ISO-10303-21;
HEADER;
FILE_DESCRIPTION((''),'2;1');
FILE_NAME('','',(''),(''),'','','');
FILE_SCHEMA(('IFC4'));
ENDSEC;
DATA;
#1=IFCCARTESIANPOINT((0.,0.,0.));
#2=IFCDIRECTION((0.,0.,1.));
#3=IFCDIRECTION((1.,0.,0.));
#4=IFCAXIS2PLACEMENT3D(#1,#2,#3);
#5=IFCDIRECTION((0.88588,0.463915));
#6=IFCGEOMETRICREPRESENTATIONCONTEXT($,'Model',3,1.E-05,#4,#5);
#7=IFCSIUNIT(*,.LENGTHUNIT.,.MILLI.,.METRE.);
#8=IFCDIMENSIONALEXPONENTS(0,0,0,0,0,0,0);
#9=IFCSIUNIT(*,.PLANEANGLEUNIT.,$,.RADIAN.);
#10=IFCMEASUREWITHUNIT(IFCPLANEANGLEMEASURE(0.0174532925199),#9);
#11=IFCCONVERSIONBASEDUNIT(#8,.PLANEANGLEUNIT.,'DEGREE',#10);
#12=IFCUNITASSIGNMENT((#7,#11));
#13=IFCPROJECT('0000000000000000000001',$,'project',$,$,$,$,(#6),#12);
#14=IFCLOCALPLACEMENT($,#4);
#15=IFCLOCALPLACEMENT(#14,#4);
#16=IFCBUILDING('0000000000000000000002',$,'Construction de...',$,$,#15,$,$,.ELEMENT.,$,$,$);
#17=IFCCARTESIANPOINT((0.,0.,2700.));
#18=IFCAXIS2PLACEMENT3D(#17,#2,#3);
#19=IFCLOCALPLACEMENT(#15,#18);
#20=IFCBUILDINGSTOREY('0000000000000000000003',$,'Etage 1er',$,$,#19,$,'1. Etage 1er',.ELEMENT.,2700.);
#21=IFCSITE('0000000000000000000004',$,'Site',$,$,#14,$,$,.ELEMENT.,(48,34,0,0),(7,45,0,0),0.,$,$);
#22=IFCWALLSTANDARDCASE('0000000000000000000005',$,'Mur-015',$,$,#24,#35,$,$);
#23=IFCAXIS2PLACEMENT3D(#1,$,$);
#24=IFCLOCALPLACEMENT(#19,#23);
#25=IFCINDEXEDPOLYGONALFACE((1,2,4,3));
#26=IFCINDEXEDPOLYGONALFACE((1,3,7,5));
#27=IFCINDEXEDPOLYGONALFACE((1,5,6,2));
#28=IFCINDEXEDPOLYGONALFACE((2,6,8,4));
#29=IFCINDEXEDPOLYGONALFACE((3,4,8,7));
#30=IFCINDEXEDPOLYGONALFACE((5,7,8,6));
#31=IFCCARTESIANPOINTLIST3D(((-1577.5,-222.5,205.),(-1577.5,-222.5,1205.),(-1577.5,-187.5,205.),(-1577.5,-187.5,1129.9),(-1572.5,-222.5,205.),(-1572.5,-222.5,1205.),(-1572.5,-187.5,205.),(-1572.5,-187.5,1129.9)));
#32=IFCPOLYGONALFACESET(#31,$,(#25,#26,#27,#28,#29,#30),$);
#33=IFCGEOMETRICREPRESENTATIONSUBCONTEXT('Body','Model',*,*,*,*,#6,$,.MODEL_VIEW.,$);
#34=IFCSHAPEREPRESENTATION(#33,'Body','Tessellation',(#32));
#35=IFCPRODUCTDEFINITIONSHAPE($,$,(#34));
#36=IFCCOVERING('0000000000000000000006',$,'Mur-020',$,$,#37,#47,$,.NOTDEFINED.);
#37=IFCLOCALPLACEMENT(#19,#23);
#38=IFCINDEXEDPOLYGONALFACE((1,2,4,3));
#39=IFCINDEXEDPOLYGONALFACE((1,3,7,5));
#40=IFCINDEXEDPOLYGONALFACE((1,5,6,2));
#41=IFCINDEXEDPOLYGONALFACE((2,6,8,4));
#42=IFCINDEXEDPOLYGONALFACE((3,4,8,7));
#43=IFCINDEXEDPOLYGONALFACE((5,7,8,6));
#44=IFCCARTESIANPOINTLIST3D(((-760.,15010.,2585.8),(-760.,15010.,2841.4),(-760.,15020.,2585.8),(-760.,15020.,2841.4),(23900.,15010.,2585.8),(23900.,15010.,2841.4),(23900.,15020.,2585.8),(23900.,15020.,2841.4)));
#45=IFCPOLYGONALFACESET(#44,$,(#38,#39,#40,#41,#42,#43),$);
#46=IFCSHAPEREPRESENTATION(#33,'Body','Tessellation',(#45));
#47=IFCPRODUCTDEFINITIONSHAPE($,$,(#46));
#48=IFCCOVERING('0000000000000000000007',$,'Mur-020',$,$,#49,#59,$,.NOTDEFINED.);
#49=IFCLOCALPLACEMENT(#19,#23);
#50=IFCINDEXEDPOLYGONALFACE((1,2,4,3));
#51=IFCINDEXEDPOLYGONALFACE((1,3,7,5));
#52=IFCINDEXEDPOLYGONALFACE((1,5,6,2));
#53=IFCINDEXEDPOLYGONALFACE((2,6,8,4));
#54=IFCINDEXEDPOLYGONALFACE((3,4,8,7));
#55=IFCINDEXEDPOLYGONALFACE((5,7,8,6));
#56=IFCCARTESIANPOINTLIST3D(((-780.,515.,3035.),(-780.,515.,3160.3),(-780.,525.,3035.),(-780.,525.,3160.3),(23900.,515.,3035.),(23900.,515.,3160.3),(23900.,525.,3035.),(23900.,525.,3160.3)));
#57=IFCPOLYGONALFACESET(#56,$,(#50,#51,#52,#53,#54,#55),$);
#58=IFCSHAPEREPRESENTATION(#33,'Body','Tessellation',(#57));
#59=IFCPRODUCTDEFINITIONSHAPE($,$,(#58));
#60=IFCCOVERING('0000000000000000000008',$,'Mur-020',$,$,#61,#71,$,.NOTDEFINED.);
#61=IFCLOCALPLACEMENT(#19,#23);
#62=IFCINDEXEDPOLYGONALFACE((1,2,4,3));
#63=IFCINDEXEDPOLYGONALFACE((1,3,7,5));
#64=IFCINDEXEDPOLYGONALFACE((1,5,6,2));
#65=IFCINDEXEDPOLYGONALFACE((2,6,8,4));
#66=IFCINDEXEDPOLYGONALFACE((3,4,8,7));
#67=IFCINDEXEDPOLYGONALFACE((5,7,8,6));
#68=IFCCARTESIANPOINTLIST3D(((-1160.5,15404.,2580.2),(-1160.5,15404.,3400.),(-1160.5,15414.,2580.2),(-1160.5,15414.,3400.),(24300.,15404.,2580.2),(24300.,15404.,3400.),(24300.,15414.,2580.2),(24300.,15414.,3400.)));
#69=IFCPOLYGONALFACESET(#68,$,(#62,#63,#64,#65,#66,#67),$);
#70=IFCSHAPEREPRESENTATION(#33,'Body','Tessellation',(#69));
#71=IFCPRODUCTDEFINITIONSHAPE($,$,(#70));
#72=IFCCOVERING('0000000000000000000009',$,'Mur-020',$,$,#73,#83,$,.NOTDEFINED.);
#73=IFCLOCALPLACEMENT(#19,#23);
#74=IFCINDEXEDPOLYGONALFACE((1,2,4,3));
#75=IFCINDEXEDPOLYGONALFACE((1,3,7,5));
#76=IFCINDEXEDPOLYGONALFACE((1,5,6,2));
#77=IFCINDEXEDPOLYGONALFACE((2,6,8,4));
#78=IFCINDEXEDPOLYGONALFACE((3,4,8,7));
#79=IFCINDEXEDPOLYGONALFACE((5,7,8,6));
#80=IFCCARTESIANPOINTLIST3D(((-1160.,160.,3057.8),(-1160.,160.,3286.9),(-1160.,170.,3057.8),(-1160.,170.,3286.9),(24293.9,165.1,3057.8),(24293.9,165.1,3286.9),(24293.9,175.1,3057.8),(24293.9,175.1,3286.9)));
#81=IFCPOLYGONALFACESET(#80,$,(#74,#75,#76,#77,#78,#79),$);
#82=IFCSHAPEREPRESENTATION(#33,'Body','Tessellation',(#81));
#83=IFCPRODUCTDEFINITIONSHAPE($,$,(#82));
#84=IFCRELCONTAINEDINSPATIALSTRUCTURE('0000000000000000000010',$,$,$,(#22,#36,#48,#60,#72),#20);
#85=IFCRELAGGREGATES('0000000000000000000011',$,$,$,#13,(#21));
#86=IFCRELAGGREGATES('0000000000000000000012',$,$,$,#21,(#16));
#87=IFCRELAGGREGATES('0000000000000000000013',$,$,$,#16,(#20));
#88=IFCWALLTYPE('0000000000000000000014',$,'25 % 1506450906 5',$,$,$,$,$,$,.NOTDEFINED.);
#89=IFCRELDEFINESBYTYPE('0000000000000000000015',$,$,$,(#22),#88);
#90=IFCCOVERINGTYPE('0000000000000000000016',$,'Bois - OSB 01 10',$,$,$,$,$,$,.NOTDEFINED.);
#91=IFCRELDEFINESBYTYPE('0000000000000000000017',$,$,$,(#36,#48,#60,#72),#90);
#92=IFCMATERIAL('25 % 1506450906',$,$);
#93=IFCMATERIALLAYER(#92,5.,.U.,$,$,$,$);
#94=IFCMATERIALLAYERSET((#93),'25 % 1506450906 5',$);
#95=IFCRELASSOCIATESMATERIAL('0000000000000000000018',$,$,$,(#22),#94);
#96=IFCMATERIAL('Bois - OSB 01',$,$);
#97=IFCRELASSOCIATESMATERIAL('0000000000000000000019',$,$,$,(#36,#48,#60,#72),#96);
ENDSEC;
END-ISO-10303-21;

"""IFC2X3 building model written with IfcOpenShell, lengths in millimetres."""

from ifc_helpers import new_model, entity, si_unit, converted_unit, direction, frame, origin_with_axes, place, context, subcontext, project, spatial, polyline, outline, extrude, clip, halfspace, material, layer, layer_set, layer_usage, type_object, element, save


model = new_model("IFC2X3")

# Units and contexts
model_context = context("Model", 3, precision=1e-05, world=origin_with_axes(), true_north=direction((0.88588, 0.463915)))
body_context = subcontext(model_context, "Body", "Model", "MODEL_VIEW")
ifc_project = project(units=[si_unit("LENGTHUNIT", "METRE", prefix="MILLI"), converted_unit("PLANEANGLEUNIT", "DEGREE", entity("IfcPlaneAngleMeasure", 0.0174532925199), si_unit("PLANEANGLEUNIT", "RADIAN"), dimensions=[0, 0, 0, 0, 0, 0, 0])], contexts=[model_context])

# Site, building, storey
site_placement = place(None, origin_with_axes())
site = spatial("IfcSite", under=ifc_project, at=site_placement, Name="Site", CompositionType="ELEMENT", RefLatitude=(48, 34, 0, 0), RefLongitude=(7, 45, 0, 0), RefElevation=0.0)
building_placement = place(site_placement, origin_with_axes())
building = spatial("IfcBuilding", under=site, at=building_placement, Name="Construction de...", CompositionType="ELEMENT")
storey_placement = place(building_placement, frame((0.0, 0.0, 2700.0), z_axis=(0.0, 0.0, 1.0), x_axis=(1.0, 0.0, 0.0)))
storey = spatial("IfcBuildingStorey", under=building, at=storey_placement, Name="Etage 1er", LongName="1. Etage 1er", CompositionType="ELEMENT", Elevation=2700.0)

# Shared definitions
ifc_material_1 = material(Name="25 % 1506450906")

# Wall
ifc_material_2 = material(Name="Bois - OSB 01")
ifc_layer_1 = layer(ifc_material_1, 5.0, ventilated="UNKNOWN")
ifc_layer_set_1 = layer_set([ifc_layer_1], Name="25 % 1506450906 5")
ifc_layer_usage_1 = layer_usage(ifc_layer_set_1, "AXIS2", "NEGATIVE", 2.5)
wall_type_1 = type_object("IfcWallType", Name="25 % 1506450906 5", PredefinedType="NOTDEFINED")
wall_1_placement = place(storey_placement, frame((-1575.0, -222.5, 205.0), z_axis=(0.0, 0.0, 1.0), x_axis=(0.0, 1.0, 0.0)))
element("IfcWallStandardCase", 1, at=wall_1_placement, inside=storey, type_object=wall_type_1, material=ifc_layer_usage_1, Name="Mur-015", context=body_context, shape_type="Clipping", body=[
    clip(extrude(outline(polyline([(0.0, -2.5), (35.0, -2.5), (35.0, 2.5), (0.0, 2.5), (0.0, -2.5)])), origin_with_axes(), (0.0, 0.0, 1.0), 1000.0), halfspace(frame((383.0, 0.0, 178.6), z_axis=(-0.906308, 0.0, -0.422618), x_axis=(0.0, 1.0, 0.0)), True)),
])

# Coverings
covering_type = type_object("IfcCoveringType", Name="Bois - OSB 01 10", PredefinedType="NOTDEFINED")
covering_1_placement = place(storey_placement, frame((-760.0, 15015.0, 2585.8), z_axis=(0.0, 0.0, 1.0), x_axis=(1.0, 0.0, 0.0)))
element("IfcCovering", 2, at=covering_1_placement, inside=storey, type_object=covering_type, material=ifc_material_2, Name="Mur-020", PredefinedType="NOTDEFINED", context=body_context, shape_type="SweptSolid", body=[
    extrude(outline(polyline([(0.0, -5.0), (24660.0, -5.0), (24660.0, 5.0), (0.0, 5.0), (0.0, -5.0)])), origin_with_axes(), (0.0, 0.0, 1.0), 255.6),
])
covering_2_placement = place(storey_placement, frame((-780.0, 520.0, 3035.0), z_axis=(0.0, 0.0, 1.0), x_axis=(1.0, 0.0, 0.0)))
element("IfcCovering", 3, at=covering_2_placement, inside=storey, type_object=covering_type, material=ifc_material_2, Name="Mur-020", PredefinedType="NOTDEFINED", context=body_context, shape_type="SweptSolid", body=[
    extrude(outline(polyline([(0.0, -5.0), (24680.0, -5.0), (24680.0, 5.0), (0.0, 5.0), (0.0, -5.0)])), origin_with_axes(), (0.0, 0.0, 1.0), 125.3),
])
covering_3_placement = place(storey_placement, frame((-1160.5, 15409.0, 2580.2), z_axis=(0.0, 0.0, 1.0), x_axis=(1.0, 0.0, 0.0)))
element("IfcCovering", 4, at=covering_3_placement, inside=storey, type_object=covering_type, material=ifc_material_2, Name="Mur-020", PredefinedType="NOTDEFINED", context=body_context, shape_type="SweptSolid", body=[
    extrude(outline(polyline([(0.0, -5.0), (25460.5, -5.0), (25460.5, 5.0), (0.0, 5.0), (0.0, -5.0)])), origin_with_axes(), (0.0, 0.0, 1.0), 819.8),
])
covering_4_placement = place(storey_placement, frame((-1160.0, 165.0, 3057.8), z_axis=(0.0, 0.0, 1.0), x_axis=(1.0, 0.0002, 0.0)))
element("IfcCovering", 5, at=covering_4_placement, inside=storey, type_object=covering_type, material=ifc_material_2, Name="Mur-020", PredefinedType="NOTDEFINED", context=body_context, shape_type="SweptSolid", body=[
    extrude(outline(polyline([(0.0, -5.0), (25453.9, -5.0), (25453.9, 5.0), (0.0, 5.0), (0.0, -5.0)])), origin_with_axes(), (0.0, 0.0, 1.0), 229.2),
])

save(model, "model.ifc")
